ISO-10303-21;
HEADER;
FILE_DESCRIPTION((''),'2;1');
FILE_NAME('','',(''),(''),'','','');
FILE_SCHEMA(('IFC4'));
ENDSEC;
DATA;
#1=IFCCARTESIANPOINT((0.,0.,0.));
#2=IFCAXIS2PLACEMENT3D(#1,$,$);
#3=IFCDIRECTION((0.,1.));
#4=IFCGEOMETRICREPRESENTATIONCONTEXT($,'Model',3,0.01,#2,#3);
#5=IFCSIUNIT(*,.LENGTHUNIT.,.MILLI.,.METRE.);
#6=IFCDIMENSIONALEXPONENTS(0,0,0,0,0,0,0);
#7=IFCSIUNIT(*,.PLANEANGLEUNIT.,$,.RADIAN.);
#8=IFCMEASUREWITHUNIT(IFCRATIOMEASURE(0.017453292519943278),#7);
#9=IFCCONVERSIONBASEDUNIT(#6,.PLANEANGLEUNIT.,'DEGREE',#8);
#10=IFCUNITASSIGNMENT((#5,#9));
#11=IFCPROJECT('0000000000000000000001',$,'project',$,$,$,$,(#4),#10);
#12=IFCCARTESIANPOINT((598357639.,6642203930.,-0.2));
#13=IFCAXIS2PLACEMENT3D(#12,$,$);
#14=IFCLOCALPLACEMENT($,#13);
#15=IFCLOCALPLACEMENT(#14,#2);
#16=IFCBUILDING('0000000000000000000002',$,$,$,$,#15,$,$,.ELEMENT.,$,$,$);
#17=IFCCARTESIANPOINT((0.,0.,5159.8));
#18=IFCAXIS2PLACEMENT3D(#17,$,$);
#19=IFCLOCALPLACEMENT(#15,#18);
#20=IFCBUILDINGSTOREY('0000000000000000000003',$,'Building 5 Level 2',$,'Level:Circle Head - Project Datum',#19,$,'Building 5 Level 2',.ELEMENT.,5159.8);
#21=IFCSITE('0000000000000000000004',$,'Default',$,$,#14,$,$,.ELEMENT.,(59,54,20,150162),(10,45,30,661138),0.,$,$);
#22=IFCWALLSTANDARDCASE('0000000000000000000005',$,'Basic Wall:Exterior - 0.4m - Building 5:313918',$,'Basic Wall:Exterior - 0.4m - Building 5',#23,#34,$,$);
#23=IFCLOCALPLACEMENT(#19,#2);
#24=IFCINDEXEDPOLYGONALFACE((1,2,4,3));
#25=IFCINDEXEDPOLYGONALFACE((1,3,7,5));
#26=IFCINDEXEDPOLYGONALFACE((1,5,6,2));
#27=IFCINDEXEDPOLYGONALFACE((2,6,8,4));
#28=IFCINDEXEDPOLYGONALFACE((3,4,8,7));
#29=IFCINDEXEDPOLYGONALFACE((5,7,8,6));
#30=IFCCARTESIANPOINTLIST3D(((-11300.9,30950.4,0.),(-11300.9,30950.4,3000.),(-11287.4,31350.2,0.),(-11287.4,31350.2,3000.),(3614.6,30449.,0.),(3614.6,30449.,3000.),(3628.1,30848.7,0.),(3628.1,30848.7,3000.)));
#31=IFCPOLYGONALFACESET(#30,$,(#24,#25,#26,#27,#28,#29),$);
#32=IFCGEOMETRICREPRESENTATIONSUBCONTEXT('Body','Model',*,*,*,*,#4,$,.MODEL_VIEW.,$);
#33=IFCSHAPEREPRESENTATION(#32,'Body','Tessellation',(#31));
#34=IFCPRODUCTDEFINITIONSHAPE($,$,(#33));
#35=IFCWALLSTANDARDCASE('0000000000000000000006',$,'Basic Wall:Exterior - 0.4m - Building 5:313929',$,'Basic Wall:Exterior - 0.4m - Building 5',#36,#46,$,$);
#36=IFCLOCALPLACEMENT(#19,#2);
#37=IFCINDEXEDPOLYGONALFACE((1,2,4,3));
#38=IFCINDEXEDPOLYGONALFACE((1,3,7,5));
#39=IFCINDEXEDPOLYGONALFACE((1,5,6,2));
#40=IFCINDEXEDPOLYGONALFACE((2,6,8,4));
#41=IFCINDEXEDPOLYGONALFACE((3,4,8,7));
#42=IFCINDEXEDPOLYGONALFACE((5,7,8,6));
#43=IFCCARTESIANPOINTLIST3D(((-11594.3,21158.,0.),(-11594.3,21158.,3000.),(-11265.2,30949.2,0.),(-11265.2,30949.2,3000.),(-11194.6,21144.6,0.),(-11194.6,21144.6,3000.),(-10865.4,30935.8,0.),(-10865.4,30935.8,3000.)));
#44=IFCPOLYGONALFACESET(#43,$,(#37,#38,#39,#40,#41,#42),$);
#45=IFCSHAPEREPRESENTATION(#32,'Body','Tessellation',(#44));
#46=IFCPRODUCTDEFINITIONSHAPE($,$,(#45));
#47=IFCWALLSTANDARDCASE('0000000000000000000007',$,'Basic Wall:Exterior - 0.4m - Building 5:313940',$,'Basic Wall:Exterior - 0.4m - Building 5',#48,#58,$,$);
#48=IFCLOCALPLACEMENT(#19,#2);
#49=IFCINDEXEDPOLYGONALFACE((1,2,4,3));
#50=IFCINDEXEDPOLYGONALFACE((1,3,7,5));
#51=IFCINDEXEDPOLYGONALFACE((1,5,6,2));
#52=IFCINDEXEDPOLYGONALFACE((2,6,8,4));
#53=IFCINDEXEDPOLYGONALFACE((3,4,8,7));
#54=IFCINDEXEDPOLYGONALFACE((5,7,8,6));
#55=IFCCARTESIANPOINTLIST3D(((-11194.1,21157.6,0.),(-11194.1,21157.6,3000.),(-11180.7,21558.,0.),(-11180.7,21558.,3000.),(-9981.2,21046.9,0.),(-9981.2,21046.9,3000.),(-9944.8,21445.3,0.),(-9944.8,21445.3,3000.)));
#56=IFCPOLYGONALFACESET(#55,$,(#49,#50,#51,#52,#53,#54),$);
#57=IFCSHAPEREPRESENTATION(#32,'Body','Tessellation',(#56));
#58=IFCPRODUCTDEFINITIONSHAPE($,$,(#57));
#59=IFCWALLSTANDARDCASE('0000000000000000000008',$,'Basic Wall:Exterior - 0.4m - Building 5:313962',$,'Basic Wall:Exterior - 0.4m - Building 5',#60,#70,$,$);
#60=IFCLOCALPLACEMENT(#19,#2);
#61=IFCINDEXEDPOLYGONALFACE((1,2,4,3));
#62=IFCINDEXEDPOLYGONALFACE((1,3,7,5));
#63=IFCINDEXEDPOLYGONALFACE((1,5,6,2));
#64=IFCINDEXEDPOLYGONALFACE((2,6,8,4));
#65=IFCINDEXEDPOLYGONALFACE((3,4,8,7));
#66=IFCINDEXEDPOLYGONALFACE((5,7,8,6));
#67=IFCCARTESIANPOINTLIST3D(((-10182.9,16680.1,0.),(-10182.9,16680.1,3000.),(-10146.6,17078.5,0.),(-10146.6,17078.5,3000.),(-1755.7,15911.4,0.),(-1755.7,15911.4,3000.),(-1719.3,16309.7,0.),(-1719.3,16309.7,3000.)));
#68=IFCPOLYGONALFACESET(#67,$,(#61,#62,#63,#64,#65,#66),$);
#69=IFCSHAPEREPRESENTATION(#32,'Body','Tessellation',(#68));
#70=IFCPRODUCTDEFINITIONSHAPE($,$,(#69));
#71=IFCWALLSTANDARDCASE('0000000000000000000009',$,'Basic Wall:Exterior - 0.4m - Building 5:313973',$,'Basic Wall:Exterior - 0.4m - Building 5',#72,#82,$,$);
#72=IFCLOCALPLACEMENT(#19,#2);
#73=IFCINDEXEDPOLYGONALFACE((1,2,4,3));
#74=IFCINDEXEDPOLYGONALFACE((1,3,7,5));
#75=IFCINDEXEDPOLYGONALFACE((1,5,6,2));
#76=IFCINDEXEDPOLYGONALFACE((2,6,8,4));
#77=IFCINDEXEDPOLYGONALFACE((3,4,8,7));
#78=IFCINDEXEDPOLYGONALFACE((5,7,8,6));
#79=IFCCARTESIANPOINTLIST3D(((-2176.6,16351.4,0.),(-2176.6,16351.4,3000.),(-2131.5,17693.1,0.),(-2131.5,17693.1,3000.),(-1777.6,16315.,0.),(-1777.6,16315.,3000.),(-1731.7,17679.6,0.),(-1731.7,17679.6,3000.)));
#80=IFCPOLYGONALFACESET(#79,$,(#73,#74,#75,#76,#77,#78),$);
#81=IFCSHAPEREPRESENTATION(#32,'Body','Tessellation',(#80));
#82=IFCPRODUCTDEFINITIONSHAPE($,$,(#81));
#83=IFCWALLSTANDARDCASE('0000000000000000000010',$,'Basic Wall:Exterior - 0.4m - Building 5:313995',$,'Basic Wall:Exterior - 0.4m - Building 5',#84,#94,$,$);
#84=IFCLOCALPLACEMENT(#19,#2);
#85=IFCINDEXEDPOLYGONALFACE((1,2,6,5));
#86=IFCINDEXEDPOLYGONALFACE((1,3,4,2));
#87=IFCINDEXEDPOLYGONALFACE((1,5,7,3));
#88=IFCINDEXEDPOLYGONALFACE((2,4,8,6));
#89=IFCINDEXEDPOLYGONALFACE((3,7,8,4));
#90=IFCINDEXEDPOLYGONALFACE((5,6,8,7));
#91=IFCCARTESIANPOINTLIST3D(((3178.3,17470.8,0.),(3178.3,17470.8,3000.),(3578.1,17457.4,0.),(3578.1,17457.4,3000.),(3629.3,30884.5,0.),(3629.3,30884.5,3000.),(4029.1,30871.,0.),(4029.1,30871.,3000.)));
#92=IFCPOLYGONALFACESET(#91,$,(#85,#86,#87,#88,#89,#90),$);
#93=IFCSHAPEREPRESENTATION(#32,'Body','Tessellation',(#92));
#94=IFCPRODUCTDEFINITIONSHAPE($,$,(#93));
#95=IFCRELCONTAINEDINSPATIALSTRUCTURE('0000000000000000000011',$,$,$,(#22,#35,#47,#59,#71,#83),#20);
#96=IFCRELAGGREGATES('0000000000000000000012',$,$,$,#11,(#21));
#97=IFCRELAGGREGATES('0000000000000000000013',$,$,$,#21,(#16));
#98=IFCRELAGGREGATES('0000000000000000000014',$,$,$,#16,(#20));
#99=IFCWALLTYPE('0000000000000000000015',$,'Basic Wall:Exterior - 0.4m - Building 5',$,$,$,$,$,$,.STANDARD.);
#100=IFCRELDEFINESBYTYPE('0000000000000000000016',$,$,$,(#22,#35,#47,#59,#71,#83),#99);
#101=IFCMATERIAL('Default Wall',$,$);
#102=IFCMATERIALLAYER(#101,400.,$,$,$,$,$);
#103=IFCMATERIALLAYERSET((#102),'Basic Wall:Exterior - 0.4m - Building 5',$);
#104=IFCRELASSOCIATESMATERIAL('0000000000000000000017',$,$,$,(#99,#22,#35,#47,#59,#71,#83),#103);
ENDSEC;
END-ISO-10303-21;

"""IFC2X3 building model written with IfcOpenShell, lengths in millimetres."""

from ifc_helpers import new_model, entity, si_unit, converted_unit, direction, frame, frame_2d, origin, place, context, subcontext, project, spatial, polyline, rectangle, outline, extrude, material, layer, layer_set, layer_usage, type_object, element, save


model = new_model("IFC2X3")

# Units and contexts
model_context = context("Model", 3, precision=0.01, world=origin(), true_north=direction((0.0, 1.0)))
body_context = subcontext(model_context, "Body", "Model", "MODEL_VIEW")
ifc_project = project(units=[si_unit("LENGTHUNIT", "METRE", prefix="MILLI"), converted_unit("PLANEANGLEUNIT", "DEGREE", entity("IfcRatioMeasure", 0.017453292519943278), si_unit("PLANEANGLEUNIT", "RADIAN"), dimensions=[0, 0, 0, 0, 0, 0, 0])], contexts=[model_context])

# Site, building, storey
site_placement = place(None, frame((598357639.0, 6642203930.0, -0.2)))
site = spatial("IfcSite", under=ifc_project, at=site_placement, Name="Default", CompositionType="ELEMENT", RefLatitude=(59, 54, 20, 150162), RefLongitude=(10, 45, 30, 661138), RefElevation=0.0)
building_placement = place(site_placement, origin())
building = spatial("IfcBuilding", under=site, at=building_placement, CompositionType="ELEMENT")
storey_placement = place(building_placement, frame((0.0, 0.0, 5159.8)))
storey = spatial("IfcBuildingStorey", under=building, at=storey_placement, Name="Building 5 Level 2", ObjectType="Level:Circle Head - Project Datum", LongName="Building 5 Level 2", CompositionType="ELEMENT", Elevation=5159.8)

# Walls
ifc_material_1 = material(Name="Default Wall")
ifc_layer_1 = layer(ifc_material_1, 400.0)
ifc_layer_set_1 = layer_set([ifc_layer_1], Name="Basic Wall:Exterior - 0.4m - Building 5")
ifc_layer_usage_1 = layer_usage(ifc_layer_set_1, "AXIS2", "POSITIVE", -200.0)
wall_type = type_object("IfcWallType", Name="Basic Wall:Exterior - 0.4m - Building 5", PredefinedType="STANDARD", material=ifc_layer_set_1)
wall_1_placement = place(storey_placement, frame((3621.4, 30648.9, 0.0), z_axis=(0.0, 0.0, 1.0), x_axis=(-0.999435, 0.033601, 0.0)))
element("IfcWallStandardCase", 1, at=wall_1_placement, inside=storey, type_object=wall_type, material=ifc_layer_usage_1, Name="Basic Wall:Exterior - 0.4m - Building 5:313918", ObjectType="Basic Wall:Exterior - 0.4m - Building 5", context=body_context, shape_type="SweptSolid", body=[
    extrude(rectangle(XDim=14923.9, YDim=400.0, at=frame_2d((7462.0, 0.0), x_axis=(-1.0, 0.0))), origin(), (0.0, 0.0, 1.0), 3000.0),
])
wall_2_placement = place(storey_placement, frame((-11065.3, 30942.5, 0.0), z_axis=(0.0, 0.0, 1.0), x_axis=(-0.033601, -0.999435, 0.0)))
element("IfcWallStandardCase", 2, at=wall_2_placement, inside=storey, type_object=wall_type, material=ifc_layer_usage_1, Name="Basic Wall:Exterior - 0.4m - Building 5:313929", ObjectType="Basic Wall:Exterior - 0.4m - Building 5", context=body_context, shape_type="SweptSolid", body=[
    extrude(rectangle(XDim=9796.7, YDim=400.0, at=frame_2d((4898.4, 0.0), x_axis=(-1.0, 0.0))), origin(), (0.0, 0.0, 1.0), 3000.0),
])
wall_3_placement = place(storey_placement, frame((-11198.8, 21358.8, 0.0), z_axis=(0.0, 0.0, 1.0), x_axis=(0.995865, -0.090846, 0.0)))
element("IfcWallStandardCase", 3, at=wall_3_placement, inside=storey, type_object=wall_type, material=ifc_layer_usage_1, Name="Basic Wall:Exterior - 0.4m - Building 5:313940", ObjectType="Basic Wall:Exterior - 0.4m - Building 5", context=body_context, shape_type="SweptSolid", body=[
    extrude(outline(polyline([(1241.0, -200.0), (1241.0, 200.0), (0.0, 200.0), (23.0, -200.0), (1241.0, -200.0)])), origin(), (0.0, 0.0, 1.0), 3000.0),
])
wall_4_placement = place(storey_placement, frame((-10164.7, 16879.3, 0.0), z_axis=(0.0, 0.0, 1.0), x_axis=(0.995865, -0.090846, 0.0)))
element("IfcWallStandardCase", 4, at=wall_4_placement, inside=storey, type_object=wall_type, material=ifc_layer_usage_1, Name="Basic Wall:Exterior - 0.4m - Building 5:313962", ObjectType="Basic Wall:Exterior - 0.4m - Building 5", context=body_context, shape_type="SweptSolid", body=[
    extrude(rectangle(XDim=8462.2, YDim=400.0, at=frame_2d((4231.1, 0.0), x_axis=(-1.0, 0.0))), origin(), (0.0, 0.0, 1.0), 3000.0),
])
wall_5_placement = place(storey_placement, frame((-1977.5, 16321.8, 0.0), z_axis=(0.0, 0.0, 1.0), x_axis=(0.033601, 0.999435, 0.0)))
element("IfcWallStandardCase", 5, at=wall_5_placement, inside=storey, type_object=wall_type, material=ifc_layer_usage_1, Name="Basic Wall:Exterior - 0.4m - Building 5:313973", ObjectType="Basic Wall:Exterior - 0.4m - Building 5", context=body_context, shape_type="SweptSolid", body=[
    extrude(outline(polyline([(1365.3, -200.0), (1365.3, 200.0), (23.0, 200.0), (0.0, -200.0), (1365.3, -200.0)])), origin(), (0.0, 0.0, 1.0), 3000.0),
])
wall_6_placement = place(storey_placement, frame((3378.2, 17464.1, 0.0), z_axis=(0.0, 0.0, 1.0), x_axis=(0.033601, 0.999435, 0.0)))
element("IfcWallStandardCase", 6, at=wall_6_placement, inside=storey, type_object=wall_type, material=ifc_layer_usage_1, Name="Basic Wall:Exterior - 0.4m - Building 5:313995", ObjectType="Basic Wall:Exterior - 0.4m - Building 5", context=body_context, shape_type="SweptSolid", body=[
    extrude(rectangle(XDim=13421.2, YDim=400.0, at=frame_2d((6710.6, 0.0), x_axis=(-1.0, 0.0))), origin(), (0.0, 0.0, 1.0), 3000.0),
])

save(model, "model.ifc")
